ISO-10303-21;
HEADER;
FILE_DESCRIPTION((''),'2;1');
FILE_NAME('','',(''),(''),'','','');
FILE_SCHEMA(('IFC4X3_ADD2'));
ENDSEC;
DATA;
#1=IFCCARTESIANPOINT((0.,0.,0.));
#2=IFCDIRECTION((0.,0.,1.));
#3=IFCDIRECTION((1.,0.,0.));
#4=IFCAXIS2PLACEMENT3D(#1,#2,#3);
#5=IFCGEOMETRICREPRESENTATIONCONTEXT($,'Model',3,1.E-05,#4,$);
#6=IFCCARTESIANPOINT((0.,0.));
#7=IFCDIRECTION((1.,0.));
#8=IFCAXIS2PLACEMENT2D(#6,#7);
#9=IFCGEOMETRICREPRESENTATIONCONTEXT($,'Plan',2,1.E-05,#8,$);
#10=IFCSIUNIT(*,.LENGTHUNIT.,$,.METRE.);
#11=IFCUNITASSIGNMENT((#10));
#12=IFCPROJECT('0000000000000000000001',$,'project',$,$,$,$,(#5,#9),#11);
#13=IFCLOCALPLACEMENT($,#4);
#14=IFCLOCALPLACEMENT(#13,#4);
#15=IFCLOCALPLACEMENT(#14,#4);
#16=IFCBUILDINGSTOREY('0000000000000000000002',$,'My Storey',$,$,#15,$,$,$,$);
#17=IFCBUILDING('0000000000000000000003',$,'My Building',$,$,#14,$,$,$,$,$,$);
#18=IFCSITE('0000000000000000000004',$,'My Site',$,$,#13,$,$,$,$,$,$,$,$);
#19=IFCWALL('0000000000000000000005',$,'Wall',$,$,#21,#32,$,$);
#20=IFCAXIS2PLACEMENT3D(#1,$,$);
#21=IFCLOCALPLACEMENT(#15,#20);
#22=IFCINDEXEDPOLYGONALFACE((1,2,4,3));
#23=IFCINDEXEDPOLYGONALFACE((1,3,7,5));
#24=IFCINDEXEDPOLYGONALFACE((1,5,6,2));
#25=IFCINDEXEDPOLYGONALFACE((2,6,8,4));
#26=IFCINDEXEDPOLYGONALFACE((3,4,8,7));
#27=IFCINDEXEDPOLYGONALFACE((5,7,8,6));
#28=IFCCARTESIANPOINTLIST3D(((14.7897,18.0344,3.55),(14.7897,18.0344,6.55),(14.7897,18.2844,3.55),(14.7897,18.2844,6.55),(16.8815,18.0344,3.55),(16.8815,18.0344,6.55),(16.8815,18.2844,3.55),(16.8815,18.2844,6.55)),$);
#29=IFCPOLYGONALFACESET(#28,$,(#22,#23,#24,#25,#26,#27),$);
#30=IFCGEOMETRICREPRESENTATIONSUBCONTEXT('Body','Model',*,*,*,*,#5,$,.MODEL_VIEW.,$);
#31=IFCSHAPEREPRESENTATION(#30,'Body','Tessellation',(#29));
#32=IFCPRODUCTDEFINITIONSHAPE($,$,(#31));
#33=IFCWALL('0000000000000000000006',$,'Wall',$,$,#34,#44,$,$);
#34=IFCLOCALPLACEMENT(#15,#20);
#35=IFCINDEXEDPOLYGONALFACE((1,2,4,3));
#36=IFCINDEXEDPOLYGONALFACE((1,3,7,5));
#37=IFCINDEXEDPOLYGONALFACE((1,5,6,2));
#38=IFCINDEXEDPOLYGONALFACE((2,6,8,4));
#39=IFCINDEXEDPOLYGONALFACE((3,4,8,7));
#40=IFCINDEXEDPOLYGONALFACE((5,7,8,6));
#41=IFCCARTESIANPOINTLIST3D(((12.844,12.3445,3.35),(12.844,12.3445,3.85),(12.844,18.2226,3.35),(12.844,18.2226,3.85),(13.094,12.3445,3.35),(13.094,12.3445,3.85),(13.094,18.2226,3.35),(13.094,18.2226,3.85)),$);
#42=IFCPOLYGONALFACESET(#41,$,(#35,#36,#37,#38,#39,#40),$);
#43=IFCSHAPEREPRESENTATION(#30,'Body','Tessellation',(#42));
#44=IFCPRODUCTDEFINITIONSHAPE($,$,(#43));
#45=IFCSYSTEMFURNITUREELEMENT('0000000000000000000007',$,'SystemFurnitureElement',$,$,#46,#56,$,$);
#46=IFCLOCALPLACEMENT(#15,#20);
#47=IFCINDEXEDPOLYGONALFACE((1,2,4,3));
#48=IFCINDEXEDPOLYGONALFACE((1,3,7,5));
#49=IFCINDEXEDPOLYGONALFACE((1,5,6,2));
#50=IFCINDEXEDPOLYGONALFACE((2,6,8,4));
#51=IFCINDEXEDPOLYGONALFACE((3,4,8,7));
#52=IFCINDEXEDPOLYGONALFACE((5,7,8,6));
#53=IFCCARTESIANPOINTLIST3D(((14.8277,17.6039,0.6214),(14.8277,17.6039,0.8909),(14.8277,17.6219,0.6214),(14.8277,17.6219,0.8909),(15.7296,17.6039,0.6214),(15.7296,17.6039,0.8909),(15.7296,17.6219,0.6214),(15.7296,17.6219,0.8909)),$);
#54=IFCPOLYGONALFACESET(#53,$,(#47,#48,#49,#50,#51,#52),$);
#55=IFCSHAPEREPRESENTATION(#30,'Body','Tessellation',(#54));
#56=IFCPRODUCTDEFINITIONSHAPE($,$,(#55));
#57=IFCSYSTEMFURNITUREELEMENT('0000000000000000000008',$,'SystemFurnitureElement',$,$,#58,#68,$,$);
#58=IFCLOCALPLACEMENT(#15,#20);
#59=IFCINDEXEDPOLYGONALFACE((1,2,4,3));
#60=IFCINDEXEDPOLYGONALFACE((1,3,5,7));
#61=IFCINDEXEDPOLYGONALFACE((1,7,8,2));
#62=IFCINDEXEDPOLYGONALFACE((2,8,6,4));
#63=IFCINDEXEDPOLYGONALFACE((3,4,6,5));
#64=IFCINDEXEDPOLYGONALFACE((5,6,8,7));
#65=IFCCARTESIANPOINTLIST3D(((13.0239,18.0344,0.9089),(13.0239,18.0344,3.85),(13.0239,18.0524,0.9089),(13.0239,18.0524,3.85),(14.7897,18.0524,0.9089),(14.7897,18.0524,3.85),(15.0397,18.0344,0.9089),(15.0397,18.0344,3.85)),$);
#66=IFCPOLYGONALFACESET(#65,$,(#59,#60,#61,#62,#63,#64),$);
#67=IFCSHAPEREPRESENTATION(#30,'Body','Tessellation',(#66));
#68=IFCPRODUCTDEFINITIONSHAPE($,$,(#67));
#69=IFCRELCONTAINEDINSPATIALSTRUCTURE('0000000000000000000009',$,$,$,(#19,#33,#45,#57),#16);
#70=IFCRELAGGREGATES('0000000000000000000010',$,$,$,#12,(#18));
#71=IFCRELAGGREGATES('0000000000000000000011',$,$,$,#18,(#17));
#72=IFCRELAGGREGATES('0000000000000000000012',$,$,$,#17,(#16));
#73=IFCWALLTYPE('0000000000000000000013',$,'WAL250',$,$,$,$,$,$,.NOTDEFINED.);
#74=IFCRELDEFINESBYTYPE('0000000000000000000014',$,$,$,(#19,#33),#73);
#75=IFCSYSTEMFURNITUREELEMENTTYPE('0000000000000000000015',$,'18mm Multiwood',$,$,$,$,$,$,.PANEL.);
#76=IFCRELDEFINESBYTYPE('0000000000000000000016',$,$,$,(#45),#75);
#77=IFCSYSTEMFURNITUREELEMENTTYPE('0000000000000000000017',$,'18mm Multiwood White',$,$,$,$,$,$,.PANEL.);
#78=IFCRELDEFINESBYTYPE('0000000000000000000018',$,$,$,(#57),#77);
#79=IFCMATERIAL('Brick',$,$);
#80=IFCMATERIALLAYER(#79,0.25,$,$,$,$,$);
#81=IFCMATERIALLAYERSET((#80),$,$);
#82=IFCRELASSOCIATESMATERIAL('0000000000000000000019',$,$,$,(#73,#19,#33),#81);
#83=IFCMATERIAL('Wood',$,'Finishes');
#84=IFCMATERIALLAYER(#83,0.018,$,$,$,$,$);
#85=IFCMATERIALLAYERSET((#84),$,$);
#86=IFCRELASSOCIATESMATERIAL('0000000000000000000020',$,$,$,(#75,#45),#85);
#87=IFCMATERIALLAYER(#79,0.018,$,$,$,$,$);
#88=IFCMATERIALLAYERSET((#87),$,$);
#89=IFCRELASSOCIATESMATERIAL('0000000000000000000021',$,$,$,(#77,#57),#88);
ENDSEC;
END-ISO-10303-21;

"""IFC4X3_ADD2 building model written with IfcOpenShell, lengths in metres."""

from ifc_helpers import new_model, si_unit, frame, origin_with_axes, origin_2d_with_axis, place, context, subcontext, project, spatial, line, indexed_curve, outline, extrude, material, layer, layer_set, layer_usage, type_object, element, save


model = new_model("IFC4X3_ADD2")

# Units and contexts
model_context = context("Model", 3, precision=1e-05, world=origin_with_axes())
plan_context = context("Plan", 2, precision=1e-05, world=origin_2d_with_axis())
body_context = subcontext(model_context, "Body", "Model", "MODEL_VIEW")
ifc_project = project(units=[si_unit("LENGTHUNIT", "METRE")], contexts=[model_context, plan_context])

# Site, building, storey
site_placement = place(None, origin_with_axes())
site = spatial("IfcSite", under=ifc_project, at=site_placement, Name="My Site")
building_placement = place(site_placement, origin_with_axes())
building = spatial("IfcBuilding", under=site, at=building_placement, Name="My Building")
storey_placement = place(building_placement, origin_with_axes())
storey = spatial("IfcBuildingStorey", under=building, at=storey_placement, Name="My Storey")

# Shared definitions
ifc_material_1 = material(Name="Brick")

# Walls
ifc_layer_1 = layer(ifc_material_1, 0.25)
ifc_layer_set_1 = layer_set([ifc_layer_1])
ifc_layer_usage_1 = layer_usage(ifc_layer_set_1, "AXIS2", "POSITIVE", 0.0)
wall_type_1 = type_object("IfcWallType", Name="WAL250", PredefinedType="NOTDEFINED", material=ifc_layer_set_1)
wall_1_placement = place(storey_placement, frame((14.7897, 18.0344, 3.55), z_axis=(0.0, 0.0, 1.0), x_axis=(1.0, 0.000006, 0.0)))
element("IfcWall", 1, at=wall_1_placement, inside=storey, type_object=wall_type_1, material=ifc_layer_usage_1, Name="Wall", context=body_context, shape_type="SweptSolid", body=[
    extrude(outline(indexed_curve([(0.0, 0.0), (0.0, 0.25), (2.0918, 0.25), (2.0918, 0.0)], segments=[line(1, 2, 3, 4, 1)])), origin_with_axes(), (0.0, 0.0, 1.0), 3.0),
])
ifc_layer_usage_2 = layer_usage(ifc_layer_set_1, "AXIS2", "POSITIVE", 0.0)
wall_2_placement = place(storey_placement, frame((13.094, 12.3445, 3.35), z_axis=(0.0, 0.0, 1.0), x_axis=(-0.000005, 1.0, 0.0)))
element("IfcWall", 2, at=wall_2_placement, inside=storey, type_object=wall_type_1, material=ifc_layer_usage_2, Name="Wall", context=body_context, shape_type="SweptSolid", body=[
    extrude(outline(indexed_curve([(0.0, 0.0), (0.0, 0.25), (5.8781, 0.25), (5.8781, 0.0)], segments=[line(1, 2, 3, 4, 1)])), origin_with_axes(), (0.0, 0.0, 1.0), 0.5),
])

# System furniture elements
ifc_material_2 = material(Name="Wood", Category="Finishes")
ifc_layer_2 = layer(ifc_material_2, 0.018)
ifc_layer_set_2 = layer_set([ifc_layer_2])
ifc_layer_usage_3 = layer_usage(ifc_layer_set_2, "AXIS2", "POSITIVE", 0.0)
system_furniture_element_type_1 = type_object("IfcSystemFurnitureElementType", Name="18mm Multiwood", PredefinedType="PANEL", material=ifc_layer_set_2)
system_furniture_element_1_placement = place(storey_placement, frame((14.8277, 17.6039, 0.6214), z_axis=(0.0, 0.0, 1.0), x_axis=(1.0, 0.0, 0.0)))
element("IfcSystemFurnitureElement", 3, at=system_furniture_element_1_placement, inside=storey, type_object=system_furniture_element_type_1, material=ifc_layer_usage_3, Name="SystemFurnitureElement", context=body_context, shape_type="SweptSolid", body=[
    extrude(outline(indexed_curve([(0.0, 0.0), (0.0, 0.018), (0.9019, 0.018), (0.9019, 0.0)], segments=[line(1, 2, 3, 4, 1)])), origin_with_axes(), (0.0, 0.0, 1.0), 0.2695),
])
ifc_layer_3 = layer(ifc_material_1, 0.018)
ifc_layer_set_3 = layer_set([ifc_layer_3])
ifc_layer_usage_4 = layer_usage(ifc_layer_set_3, "AXIS2", "POSITIVE", 0.0)
system_furniture_element_type_2 = type_object("IfcSystemFurnitureElementType", Name="18mm Multiwood White", PredefinedType="PANEL", material=ifc_layer_set_3)
system_furniture_element_2_placement = place(storey_placement, frame((13.0239, 18.0344, 0.9089), z_axis=(0.0, 0.0, 1.0), x_axis=(1.0, 0.0, 0.0)))
element("IfcSystemFurnitureElement", 4, at=system_furniture_element_2_placement, inside=storey, type_object=system_furniture_element_type_2, material=ifc_layer_usage_4, Name="SystemFurnitureElement", context=body_context, shape_type="SweptSolid", body=[
    extrude(outline(indexed_curve([(0.0, 0.0), (0.0, 0.018), (1.7658, 0.018), (2.0158, 0.0)], segments=[line(1, 2, 3, 4, 1)])), origin_with_axes(), (0.0, 0.0, 1.0), 2.9411),
])

save(model, "model.ifc")
